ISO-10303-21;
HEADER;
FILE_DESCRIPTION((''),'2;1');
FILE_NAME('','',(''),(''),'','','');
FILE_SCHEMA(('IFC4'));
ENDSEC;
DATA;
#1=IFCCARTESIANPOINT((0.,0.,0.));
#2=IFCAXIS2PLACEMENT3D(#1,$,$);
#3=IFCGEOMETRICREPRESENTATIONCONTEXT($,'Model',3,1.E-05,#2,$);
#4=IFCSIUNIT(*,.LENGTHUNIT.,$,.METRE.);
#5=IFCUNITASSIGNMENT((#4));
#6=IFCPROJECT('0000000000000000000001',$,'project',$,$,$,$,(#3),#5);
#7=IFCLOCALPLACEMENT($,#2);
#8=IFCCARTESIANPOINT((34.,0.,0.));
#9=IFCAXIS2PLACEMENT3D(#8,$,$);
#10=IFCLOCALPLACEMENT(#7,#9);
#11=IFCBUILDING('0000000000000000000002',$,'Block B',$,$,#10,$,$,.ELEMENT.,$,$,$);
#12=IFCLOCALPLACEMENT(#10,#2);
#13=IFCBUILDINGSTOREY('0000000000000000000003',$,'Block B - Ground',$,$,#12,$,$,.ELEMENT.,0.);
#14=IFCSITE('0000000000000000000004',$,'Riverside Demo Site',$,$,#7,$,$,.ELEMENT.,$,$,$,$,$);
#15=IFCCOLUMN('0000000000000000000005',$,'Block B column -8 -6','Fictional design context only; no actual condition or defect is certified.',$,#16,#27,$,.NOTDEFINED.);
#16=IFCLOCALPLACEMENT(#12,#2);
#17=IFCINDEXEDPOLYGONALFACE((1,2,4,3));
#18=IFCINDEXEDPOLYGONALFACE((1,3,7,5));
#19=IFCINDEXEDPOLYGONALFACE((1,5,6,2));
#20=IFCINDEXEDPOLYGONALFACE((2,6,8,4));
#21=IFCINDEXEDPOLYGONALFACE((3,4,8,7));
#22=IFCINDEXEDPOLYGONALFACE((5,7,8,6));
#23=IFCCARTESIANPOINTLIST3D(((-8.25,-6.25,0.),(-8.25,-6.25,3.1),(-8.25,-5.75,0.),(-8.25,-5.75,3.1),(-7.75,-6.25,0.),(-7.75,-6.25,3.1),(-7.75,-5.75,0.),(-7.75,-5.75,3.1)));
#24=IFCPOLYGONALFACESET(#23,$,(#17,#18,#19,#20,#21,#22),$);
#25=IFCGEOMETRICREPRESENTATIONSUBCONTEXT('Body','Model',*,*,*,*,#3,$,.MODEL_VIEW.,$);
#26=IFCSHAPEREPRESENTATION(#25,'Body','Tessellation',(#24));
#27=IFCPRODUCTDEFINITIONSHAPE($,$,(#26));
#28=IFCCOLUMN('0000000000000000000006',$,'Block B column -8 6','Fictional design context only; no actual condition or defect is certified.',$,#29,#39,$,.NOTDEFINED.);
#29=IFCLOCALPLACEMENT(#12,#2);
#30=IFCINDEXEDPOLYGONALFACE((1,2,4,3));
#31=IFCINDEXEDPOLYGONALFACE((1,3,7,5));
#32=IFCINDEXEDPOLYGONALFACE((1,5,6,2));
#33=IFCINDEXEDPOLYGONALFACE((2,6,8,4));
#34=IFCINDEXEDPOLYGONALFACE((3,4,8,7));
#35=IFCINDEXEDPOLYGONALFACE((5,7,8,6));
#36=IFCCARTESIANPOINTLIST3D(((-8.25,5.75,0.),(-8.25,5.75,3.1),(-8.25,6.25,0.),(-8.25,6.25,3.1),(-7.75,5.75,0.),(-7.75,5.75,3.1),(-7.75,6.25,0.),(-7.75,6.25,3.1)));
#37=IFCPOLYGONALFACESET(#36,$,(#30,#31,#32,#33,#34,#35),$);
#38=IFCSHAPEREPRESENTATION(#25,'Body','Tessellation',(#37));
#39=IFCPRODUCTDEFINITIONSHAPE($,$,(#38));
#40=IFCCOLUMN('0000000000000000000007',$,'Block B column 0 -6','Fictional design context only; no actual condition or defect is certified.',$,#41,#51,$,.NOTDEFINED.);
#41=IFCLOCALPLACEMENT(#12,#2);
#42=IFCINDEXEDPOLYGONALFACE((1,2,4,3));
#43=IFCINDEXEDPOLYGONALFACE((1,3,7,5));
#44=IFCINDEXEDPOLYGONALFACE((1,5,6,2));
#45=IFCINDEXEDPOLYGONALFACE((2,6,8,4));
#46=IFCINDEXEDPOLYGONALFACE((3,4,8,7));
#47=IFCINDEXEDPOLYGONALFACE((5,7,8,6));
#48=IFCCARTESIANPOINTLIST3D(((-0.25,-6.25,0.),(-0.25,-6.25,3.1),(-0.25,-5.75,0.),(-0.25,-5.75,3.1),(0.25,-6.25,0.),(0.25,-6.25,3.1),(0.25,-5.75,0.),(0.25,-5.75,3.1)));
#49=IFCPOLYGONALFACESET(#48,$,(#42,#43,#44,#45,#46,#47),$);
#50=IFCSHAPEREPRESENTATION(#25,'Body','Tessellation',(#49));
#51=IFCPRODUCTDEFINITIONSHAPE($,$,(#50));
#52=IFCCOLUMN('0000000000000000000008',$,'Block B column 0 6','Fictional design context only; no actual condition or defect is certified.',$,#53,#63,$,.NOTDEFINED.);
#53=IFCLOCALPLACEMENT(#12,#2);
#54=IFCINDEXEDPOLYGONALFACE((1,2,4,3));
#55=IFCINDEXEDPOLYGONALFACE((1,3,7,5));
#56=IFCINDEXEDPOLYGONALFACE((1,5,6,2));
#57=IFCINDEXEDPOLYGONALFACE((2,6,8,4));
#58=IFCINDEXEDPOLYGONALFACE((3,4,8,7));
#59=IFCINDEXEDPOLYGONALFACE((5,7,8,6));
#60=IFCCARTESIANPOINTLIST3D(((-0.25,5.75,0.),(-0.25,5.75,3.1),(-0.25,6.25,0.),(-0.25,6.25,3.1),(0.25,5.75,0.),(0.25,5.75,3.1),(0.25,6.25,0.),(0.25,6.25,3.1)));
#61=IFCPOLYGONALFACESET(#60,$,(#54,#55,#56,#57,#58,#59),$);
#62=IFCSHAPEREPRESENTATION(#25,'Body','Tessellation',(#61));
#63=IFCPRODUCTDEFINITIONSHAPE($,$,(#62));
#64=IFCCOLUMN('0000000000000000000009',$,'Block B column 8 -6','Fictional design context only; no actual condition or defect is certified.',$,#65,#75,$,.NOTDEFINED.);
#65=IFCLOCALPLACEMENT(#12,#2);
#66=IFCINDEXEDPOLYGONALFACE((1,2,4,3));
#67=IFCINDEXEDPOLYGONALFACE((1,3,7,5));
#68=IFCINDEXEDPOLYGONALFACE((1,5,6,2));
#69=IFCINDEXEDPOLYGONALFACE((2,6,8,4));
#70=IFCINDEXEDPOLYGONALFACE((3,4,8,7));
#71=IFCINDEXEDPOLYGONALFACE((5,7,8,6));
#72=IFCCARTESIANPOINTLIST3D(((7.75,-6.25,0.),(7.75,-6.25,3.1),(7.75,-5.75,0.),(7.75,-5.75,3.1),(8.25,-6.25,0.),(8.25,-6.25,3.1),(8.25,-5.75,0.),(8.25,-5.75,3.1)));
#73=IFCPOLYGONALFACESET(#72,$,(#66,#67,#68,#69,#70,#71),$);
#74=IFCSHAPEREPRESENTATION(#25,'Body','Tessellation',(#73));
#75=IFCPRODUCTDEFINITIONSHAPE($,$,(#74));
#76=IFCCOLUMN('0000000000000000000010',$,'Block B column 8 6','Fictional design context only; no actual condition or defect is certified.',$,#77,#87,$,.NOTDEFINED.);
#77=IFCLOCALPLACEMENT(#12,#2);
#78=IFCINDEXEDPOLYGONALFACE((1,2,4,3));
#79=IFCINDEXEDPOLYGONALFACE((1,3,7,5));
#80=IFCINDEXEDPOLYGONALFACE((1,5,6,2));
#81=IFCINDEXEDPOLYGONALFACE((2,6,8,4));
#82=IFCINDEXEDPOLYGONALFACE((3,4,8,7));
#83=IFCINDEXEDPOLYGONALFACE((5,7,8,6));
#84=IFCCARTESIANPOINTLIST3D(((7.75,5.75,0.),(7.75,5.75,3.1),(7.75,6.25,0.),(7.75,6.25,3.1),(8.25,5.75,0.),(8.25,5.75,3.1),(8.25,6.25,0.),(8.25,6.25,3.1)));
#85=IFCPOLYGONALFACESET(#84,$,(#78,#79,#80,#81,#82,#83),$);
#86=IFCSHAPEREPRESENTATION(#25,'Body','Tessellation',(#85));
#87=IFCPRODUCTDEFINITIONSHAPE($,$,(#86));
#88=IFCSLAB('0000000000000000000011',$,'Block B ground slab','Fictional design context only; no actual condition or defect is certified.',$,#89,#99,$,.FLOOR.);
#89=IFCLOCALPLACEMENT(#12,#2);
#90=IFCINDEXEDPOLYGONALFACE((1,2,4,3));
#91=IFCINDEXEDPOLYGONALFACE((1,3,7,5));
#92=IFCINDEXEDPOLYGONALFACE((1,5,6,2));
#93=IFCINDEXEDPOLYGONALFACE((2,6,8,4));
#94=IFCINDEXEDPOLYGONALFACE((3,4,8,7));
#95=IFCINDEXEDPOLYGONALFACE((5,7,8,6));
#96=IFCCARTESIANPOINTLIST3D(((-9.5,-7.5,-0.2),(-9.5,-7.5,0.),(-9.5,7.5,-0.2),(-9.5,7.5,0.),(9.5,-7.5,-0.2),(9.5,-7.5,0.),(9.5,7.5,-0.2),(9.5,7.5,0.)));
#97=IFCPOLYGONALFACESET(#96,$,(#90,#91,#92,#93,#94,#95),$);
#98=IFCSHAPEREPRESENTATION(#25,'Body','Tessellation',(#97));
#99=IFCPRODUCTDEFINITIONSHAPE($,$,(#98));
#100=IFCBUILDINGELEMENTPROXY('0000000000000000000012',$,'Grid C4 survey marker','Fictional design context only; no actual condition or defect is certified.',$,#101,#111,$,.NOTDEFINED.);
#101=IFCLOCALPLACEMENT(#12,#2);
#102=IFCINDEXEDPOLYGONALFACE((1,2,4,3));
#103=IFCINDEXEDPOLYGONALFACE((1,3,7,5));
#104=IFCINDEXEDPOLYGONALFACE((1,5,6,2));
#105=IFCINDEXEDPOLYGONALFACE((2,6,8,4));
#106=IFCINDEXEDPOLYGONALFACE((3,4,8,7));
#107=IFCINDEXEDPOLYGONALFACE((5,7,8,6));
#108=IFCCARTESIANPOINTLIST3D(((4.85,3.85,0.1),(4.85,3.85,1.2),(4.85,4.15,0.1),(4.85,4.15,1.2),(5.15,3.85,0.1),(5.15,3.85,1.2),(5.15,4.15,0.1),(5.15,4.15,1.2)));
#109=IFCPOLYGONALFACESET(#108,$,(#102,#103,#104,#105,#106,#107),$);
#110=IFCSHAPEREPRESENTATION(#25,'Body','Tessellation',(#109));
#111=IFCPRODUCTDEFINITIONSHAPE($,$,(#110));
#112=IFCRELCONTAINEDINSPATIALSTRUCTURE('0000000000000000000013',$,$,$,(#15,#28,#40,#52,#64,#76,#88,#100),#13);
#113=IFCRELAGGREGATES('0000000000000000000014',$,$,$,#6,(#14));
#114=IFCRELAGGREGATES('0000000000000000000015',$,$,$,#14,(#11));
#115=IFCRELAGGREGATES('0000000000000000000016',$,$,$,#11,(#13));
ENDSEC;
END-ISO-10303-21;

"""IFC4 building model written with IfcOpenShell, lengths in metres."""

from ifc_helpers import new_model, si_unit, frame, origin, origin_2d, place, context, subcontext, project, spatial, rectangle, extrude, element, save


model = new_model("IFC4")

# Units and contexts
model_context = context("Model", 3, precision=1e-05, world=origin())
body_context = subcontext(model_context, "Body", "Model", "MODEL_VIEW")
ifc_project = project(units=[si_unit("LENGTHUNIT", "METRE")], contexts=[model_context])

# Site, building, storey
site_placement = place(None, origin())
site = spatial("IfcSite", under=ifc_project, at=site_placement, Name="Riverside Demo Site", CompositionType="ELEMENT")
building_placement = place(site_placement, frame((34.0, 0.0, 0.0)))
building = spatial("IfcBuilding", under=site, at=building_placement, Name="Block B", CompositionType="ELEMENT")
storey_placement = place(building_placement, origin())
storey = spatial("IfcBuildingStorey", under=building, at=storey_placement, Name="Block B - Ground", CompositionType="ELEMENT", Elevation=0.0)

# Columns
for number, where, name in (
    (1, (-8.0, -6.0, 0.0), "Block B column -8 -6"),
    (2, (-8.0, 6.0, 0.0), "Block B column -8 6"),
    (3, (0.0, -6.0, 0.0), "Block B column 0 -6"),
    (4, (0.0, 6.0, 0.0), "Block B column 0 6"),
    (5, (8.0, -6.0, 0.0), "Block B column 8 -6"),
    (6, (8.0, 6.0, 0.0), "Block B column 8 6"),
):
    element("IfcColumn", number, at=place(storey_placement, frame(where)), inside=storey, Name=name, Description="Fictional design context only; no actual condition or defect is certified.", PredefinedType="NOTDEFINED", context=body_context, shape_type="SweptSolid", body=[
        extrude(rectangle(XDim=0.5, YDim=0.5, at=origin_2d()), origin(), (0.0, 0.0, 1.0), 3.1),
    ])

# Slab
slab_placement = place(storey_placement, frame((0.0, 0.0, -0.2)))
element("IfcSlab", 7, at=slab_placement, inside=storey, Name="Block B ground slab", Description="Fictional design context only; no actual condition or defect is certified.", PredefinedType="FLOOR", context=body_context, shape_type="SweptSolid", body=[
    extrude(rectangle(XDim=19.0, YDim=15.0, at=origin_2d()), origin(), (0.0, 0.0, 1.0), 0.2),
])

# Building element proxy
proxy_placement = place(storey_placement, frame((5.0, 4.0, 0.1)))
element("IfcBuildingElementProxy", 8, at=proxy_placement, inside=storey, Name="Grid C4 survey marker", Description="Fictional design context only; no actual condition or defect is certified.", PredefinedType="NOTDEFINED", context=body_context, shape_type="SweptSolid", body=[
    extrude(rectangle(XDim=0.3, YDim=0.3, at=origin_2d()), origin(), (0.0, 0.0, 1.0), 1.1),
])

save(model, "model.ifc")
